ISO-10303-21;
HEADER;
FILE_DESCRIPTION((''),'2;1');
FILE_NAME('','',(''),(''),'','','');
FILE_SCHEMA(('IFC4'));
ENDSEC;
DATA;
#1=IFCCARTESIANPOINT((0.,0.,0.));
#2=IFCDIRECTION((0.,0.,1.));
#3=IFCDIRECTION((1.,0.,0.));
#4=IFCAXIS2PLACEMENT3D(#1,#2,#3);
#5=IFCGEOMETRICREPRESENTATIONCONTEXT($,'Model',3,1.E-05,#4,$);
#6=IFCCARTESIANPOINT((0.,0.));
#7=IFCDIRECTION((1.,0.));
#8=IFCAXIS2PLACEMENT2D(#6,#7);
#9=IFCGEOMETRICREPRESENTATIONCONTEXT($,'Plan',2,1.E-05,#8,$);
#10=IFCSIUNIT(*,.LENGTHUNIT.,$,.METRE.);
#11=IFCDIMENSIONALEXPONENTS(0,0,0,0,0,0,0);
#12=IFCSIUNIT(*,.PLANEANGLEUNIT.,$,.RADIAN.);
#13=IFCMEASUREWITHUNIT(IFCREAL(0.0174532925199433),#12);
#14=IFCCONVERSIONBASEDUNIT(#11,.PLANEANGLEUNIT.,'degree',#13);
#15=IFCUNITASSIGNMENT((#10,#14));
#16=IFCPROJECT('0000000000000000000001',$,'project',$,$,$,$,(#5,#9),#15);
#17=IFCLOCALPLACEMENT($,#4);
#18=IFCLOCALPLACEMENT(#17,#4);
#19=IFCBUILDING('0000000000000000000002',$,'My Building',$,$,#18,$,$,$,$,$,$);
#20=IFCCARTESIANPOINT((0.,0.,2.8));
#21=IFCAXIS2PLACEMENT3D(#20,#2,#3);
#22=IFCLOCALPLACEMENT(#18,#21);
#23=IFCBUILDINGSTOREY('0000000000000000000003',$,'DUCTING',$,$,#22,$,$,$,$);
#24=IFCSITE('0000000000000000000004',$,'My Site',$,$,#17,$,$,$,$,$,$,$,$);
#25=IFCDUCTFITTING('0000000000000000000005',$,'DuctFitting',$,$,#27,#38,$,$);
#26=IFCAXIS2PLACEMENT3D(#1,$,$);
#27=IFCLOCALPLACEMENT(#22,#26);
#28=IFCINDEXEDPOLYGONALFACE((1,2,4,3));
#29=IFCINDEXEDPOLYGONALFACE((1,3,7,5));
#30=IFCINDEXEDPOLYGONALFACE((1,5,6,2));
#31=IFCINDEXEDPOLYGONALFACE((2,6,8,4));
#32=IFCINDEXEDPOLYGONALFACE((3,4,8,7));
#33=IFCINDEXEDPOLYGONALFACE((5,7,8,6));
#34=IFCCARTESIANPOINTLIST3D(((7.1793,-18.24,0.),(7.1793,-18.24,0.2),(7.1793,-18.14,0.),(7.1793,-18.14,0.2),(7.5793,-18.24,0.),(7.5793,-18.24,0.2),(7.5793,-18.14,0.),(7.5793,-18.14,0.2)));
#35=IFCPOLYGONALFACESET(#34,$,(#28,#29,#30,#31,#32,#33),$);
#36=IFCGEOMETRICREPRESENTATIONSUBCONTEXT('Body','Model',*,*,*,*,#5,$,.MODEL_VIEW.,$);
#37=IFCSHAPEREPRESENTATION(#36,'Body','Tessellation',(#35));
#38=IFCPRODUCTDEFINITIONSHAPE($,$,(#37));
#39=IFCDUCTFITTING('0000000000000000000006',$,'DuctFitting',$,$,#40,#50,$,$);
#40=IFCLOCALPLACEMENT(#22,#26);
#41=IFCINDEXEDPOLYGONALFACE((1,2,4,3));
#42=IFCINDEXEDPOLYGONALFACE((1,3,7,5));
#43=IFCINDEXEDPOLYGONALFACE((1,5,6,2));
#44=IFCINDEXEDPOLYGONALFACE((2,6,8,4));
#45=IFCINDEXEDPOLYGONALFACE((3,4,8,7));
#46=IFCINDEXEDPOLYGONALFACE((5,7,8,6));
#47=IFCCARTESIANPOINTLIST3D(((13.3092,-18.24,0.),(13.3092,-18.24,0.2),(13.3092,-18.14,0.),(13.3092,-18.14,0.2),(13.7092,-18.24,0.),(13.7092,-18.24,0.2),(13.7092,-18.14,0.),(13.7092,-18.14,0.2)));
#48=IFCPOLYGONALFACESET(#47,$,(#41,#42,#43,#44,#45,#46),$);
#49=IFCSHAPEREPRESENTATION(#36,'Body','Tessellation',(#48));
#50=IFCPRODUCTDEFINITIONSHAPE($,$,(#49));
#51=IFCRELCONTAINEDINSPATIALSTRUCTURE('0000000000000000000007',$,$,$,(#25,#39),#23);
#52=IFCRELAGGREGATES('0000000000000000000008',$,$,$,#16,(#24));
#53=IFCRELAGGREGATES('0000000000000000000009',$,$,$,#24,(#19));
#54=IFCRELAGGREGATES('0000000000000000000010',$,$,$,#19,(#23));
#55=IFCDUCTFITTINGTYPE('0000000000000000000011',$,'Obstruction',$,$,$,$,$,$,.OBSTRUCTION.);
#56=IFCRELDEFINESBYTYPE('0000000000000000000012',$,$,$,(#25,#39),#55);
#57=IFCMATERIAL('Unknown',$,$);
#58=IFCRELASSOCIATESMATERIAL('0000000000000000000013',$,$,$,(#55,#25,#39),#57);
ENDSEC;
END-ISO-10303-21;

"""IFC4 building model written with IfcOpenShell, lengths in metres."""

from ifc_helpers import new_model, entity, si_unit, converted_unit, frame, origin_with_axes, origin_2d_with_axis, place, context, subcontext, project, spatial, rectangle, extrude, material, material_profile, profile_set, profile_usage, type_object, element, save


model = new_model("IFC4")

# Units and contexts
model_context = context("Model", 3, precision=1e-05, world=origin_with_axes())
plan_context = context("Plan", 2, precision=1e-05, world=origin_2d_with_axis())
body_context = subcontext(model_context, "Body", "Model", "MODEL_VIEW")
ifc_project = project(units=[si_unit("LENGTHUNIT", "METRE"), converted_unit("PLANEANGLEUNIT", "degree", entity("IfcReal", 0.0174532925199433), si_unit("PLANEANGLEUNIT", "RADIAN"), dimensions=[0, 0, 0, 0, 0, 0, 0])], contexts=[model_context, plan_context])

# Site, building, storey
site_placement = place(None, origin_with_axes())
site = spatial("IfcSite", under=ifc_project, at=site_placement, Name="My Site")
building_placement = place(site_placement, origin_with_axes())
building = spatial("IfcBuilding", under=site, at=building_placement, Name="My Building")
storey_placement = place(building_placement, frame((0.0, 0.0, 2.8), z_axis=(0.0, 0.0, 1.0), x_axis=(1.0, 0.0, 0.0)))
storey = spatial("IfcBuildingStorey", under=building, at=storey_placement, Name="DUCTING")

# Shared definitions
ifc_material = material(Name="Unknown")

# Duct fittings
ifc_material_profile_1 = material_profile(ifc_material, rectangle(XDim=0.4, YDim=0.2))
ifc_profile_set_1 = profile_set([ifc_material_profile_1])
duct_fitting_type_1 = type_object("IfcDuctFittingType", Name="Obstruction", PredefinedType="OBSTRUCTION", material=ifc_profile_set_1)
ifc_profile_usage_1 = profile_usage(ifc_profile_set_1, cardinal=5)
duct_fitting_1_placement = place(storey_placement, frame((7.3793, -18.14, 0.1), z_axis=(0.0, -1.0, -0.000004), x_axis=(1.0, 0.0, 0.0)))
element("IfcDuctFitting", 1, at=duct_fitting_1_placement, inside=storey, type_object=duct_fitting_type_1, material=ifc_profile_usage_1, Name="DuctFitting", context=body_context, shape_type="SweptSolid", body=[
    extrude(rectangle(XDim=0.4, YDim=0.2), origin_with_axes(), (0.0, 0.0, 1.0), 0.1),
])
ifc_profile_usage_2 = profile_usage(ifc_profile_set_1, cardinal=5)
duct_fitting_2_placement = place(storey_placement, frame((13.5092, -18.14, 0.1), z_axis=(0.0, -1.0, -0.000004), x_axis=(1.0, 0.0, 0.0)))
element("IfcDuctFitting", 2, at=duct_fitting_2_placement, inside=storey, type_object=duct_fitting_type_1, material=ifc_profile_usage_2, Name="DuctFitting", context=body_context, shape_type="SweptSolid", body=[
    extrude(rectangle(XDim=0.4, YDim=0.2), origin_with_axes(), (0.0, 0.0, 1.0), 0.1),
])

save(model, "model.ifc")
